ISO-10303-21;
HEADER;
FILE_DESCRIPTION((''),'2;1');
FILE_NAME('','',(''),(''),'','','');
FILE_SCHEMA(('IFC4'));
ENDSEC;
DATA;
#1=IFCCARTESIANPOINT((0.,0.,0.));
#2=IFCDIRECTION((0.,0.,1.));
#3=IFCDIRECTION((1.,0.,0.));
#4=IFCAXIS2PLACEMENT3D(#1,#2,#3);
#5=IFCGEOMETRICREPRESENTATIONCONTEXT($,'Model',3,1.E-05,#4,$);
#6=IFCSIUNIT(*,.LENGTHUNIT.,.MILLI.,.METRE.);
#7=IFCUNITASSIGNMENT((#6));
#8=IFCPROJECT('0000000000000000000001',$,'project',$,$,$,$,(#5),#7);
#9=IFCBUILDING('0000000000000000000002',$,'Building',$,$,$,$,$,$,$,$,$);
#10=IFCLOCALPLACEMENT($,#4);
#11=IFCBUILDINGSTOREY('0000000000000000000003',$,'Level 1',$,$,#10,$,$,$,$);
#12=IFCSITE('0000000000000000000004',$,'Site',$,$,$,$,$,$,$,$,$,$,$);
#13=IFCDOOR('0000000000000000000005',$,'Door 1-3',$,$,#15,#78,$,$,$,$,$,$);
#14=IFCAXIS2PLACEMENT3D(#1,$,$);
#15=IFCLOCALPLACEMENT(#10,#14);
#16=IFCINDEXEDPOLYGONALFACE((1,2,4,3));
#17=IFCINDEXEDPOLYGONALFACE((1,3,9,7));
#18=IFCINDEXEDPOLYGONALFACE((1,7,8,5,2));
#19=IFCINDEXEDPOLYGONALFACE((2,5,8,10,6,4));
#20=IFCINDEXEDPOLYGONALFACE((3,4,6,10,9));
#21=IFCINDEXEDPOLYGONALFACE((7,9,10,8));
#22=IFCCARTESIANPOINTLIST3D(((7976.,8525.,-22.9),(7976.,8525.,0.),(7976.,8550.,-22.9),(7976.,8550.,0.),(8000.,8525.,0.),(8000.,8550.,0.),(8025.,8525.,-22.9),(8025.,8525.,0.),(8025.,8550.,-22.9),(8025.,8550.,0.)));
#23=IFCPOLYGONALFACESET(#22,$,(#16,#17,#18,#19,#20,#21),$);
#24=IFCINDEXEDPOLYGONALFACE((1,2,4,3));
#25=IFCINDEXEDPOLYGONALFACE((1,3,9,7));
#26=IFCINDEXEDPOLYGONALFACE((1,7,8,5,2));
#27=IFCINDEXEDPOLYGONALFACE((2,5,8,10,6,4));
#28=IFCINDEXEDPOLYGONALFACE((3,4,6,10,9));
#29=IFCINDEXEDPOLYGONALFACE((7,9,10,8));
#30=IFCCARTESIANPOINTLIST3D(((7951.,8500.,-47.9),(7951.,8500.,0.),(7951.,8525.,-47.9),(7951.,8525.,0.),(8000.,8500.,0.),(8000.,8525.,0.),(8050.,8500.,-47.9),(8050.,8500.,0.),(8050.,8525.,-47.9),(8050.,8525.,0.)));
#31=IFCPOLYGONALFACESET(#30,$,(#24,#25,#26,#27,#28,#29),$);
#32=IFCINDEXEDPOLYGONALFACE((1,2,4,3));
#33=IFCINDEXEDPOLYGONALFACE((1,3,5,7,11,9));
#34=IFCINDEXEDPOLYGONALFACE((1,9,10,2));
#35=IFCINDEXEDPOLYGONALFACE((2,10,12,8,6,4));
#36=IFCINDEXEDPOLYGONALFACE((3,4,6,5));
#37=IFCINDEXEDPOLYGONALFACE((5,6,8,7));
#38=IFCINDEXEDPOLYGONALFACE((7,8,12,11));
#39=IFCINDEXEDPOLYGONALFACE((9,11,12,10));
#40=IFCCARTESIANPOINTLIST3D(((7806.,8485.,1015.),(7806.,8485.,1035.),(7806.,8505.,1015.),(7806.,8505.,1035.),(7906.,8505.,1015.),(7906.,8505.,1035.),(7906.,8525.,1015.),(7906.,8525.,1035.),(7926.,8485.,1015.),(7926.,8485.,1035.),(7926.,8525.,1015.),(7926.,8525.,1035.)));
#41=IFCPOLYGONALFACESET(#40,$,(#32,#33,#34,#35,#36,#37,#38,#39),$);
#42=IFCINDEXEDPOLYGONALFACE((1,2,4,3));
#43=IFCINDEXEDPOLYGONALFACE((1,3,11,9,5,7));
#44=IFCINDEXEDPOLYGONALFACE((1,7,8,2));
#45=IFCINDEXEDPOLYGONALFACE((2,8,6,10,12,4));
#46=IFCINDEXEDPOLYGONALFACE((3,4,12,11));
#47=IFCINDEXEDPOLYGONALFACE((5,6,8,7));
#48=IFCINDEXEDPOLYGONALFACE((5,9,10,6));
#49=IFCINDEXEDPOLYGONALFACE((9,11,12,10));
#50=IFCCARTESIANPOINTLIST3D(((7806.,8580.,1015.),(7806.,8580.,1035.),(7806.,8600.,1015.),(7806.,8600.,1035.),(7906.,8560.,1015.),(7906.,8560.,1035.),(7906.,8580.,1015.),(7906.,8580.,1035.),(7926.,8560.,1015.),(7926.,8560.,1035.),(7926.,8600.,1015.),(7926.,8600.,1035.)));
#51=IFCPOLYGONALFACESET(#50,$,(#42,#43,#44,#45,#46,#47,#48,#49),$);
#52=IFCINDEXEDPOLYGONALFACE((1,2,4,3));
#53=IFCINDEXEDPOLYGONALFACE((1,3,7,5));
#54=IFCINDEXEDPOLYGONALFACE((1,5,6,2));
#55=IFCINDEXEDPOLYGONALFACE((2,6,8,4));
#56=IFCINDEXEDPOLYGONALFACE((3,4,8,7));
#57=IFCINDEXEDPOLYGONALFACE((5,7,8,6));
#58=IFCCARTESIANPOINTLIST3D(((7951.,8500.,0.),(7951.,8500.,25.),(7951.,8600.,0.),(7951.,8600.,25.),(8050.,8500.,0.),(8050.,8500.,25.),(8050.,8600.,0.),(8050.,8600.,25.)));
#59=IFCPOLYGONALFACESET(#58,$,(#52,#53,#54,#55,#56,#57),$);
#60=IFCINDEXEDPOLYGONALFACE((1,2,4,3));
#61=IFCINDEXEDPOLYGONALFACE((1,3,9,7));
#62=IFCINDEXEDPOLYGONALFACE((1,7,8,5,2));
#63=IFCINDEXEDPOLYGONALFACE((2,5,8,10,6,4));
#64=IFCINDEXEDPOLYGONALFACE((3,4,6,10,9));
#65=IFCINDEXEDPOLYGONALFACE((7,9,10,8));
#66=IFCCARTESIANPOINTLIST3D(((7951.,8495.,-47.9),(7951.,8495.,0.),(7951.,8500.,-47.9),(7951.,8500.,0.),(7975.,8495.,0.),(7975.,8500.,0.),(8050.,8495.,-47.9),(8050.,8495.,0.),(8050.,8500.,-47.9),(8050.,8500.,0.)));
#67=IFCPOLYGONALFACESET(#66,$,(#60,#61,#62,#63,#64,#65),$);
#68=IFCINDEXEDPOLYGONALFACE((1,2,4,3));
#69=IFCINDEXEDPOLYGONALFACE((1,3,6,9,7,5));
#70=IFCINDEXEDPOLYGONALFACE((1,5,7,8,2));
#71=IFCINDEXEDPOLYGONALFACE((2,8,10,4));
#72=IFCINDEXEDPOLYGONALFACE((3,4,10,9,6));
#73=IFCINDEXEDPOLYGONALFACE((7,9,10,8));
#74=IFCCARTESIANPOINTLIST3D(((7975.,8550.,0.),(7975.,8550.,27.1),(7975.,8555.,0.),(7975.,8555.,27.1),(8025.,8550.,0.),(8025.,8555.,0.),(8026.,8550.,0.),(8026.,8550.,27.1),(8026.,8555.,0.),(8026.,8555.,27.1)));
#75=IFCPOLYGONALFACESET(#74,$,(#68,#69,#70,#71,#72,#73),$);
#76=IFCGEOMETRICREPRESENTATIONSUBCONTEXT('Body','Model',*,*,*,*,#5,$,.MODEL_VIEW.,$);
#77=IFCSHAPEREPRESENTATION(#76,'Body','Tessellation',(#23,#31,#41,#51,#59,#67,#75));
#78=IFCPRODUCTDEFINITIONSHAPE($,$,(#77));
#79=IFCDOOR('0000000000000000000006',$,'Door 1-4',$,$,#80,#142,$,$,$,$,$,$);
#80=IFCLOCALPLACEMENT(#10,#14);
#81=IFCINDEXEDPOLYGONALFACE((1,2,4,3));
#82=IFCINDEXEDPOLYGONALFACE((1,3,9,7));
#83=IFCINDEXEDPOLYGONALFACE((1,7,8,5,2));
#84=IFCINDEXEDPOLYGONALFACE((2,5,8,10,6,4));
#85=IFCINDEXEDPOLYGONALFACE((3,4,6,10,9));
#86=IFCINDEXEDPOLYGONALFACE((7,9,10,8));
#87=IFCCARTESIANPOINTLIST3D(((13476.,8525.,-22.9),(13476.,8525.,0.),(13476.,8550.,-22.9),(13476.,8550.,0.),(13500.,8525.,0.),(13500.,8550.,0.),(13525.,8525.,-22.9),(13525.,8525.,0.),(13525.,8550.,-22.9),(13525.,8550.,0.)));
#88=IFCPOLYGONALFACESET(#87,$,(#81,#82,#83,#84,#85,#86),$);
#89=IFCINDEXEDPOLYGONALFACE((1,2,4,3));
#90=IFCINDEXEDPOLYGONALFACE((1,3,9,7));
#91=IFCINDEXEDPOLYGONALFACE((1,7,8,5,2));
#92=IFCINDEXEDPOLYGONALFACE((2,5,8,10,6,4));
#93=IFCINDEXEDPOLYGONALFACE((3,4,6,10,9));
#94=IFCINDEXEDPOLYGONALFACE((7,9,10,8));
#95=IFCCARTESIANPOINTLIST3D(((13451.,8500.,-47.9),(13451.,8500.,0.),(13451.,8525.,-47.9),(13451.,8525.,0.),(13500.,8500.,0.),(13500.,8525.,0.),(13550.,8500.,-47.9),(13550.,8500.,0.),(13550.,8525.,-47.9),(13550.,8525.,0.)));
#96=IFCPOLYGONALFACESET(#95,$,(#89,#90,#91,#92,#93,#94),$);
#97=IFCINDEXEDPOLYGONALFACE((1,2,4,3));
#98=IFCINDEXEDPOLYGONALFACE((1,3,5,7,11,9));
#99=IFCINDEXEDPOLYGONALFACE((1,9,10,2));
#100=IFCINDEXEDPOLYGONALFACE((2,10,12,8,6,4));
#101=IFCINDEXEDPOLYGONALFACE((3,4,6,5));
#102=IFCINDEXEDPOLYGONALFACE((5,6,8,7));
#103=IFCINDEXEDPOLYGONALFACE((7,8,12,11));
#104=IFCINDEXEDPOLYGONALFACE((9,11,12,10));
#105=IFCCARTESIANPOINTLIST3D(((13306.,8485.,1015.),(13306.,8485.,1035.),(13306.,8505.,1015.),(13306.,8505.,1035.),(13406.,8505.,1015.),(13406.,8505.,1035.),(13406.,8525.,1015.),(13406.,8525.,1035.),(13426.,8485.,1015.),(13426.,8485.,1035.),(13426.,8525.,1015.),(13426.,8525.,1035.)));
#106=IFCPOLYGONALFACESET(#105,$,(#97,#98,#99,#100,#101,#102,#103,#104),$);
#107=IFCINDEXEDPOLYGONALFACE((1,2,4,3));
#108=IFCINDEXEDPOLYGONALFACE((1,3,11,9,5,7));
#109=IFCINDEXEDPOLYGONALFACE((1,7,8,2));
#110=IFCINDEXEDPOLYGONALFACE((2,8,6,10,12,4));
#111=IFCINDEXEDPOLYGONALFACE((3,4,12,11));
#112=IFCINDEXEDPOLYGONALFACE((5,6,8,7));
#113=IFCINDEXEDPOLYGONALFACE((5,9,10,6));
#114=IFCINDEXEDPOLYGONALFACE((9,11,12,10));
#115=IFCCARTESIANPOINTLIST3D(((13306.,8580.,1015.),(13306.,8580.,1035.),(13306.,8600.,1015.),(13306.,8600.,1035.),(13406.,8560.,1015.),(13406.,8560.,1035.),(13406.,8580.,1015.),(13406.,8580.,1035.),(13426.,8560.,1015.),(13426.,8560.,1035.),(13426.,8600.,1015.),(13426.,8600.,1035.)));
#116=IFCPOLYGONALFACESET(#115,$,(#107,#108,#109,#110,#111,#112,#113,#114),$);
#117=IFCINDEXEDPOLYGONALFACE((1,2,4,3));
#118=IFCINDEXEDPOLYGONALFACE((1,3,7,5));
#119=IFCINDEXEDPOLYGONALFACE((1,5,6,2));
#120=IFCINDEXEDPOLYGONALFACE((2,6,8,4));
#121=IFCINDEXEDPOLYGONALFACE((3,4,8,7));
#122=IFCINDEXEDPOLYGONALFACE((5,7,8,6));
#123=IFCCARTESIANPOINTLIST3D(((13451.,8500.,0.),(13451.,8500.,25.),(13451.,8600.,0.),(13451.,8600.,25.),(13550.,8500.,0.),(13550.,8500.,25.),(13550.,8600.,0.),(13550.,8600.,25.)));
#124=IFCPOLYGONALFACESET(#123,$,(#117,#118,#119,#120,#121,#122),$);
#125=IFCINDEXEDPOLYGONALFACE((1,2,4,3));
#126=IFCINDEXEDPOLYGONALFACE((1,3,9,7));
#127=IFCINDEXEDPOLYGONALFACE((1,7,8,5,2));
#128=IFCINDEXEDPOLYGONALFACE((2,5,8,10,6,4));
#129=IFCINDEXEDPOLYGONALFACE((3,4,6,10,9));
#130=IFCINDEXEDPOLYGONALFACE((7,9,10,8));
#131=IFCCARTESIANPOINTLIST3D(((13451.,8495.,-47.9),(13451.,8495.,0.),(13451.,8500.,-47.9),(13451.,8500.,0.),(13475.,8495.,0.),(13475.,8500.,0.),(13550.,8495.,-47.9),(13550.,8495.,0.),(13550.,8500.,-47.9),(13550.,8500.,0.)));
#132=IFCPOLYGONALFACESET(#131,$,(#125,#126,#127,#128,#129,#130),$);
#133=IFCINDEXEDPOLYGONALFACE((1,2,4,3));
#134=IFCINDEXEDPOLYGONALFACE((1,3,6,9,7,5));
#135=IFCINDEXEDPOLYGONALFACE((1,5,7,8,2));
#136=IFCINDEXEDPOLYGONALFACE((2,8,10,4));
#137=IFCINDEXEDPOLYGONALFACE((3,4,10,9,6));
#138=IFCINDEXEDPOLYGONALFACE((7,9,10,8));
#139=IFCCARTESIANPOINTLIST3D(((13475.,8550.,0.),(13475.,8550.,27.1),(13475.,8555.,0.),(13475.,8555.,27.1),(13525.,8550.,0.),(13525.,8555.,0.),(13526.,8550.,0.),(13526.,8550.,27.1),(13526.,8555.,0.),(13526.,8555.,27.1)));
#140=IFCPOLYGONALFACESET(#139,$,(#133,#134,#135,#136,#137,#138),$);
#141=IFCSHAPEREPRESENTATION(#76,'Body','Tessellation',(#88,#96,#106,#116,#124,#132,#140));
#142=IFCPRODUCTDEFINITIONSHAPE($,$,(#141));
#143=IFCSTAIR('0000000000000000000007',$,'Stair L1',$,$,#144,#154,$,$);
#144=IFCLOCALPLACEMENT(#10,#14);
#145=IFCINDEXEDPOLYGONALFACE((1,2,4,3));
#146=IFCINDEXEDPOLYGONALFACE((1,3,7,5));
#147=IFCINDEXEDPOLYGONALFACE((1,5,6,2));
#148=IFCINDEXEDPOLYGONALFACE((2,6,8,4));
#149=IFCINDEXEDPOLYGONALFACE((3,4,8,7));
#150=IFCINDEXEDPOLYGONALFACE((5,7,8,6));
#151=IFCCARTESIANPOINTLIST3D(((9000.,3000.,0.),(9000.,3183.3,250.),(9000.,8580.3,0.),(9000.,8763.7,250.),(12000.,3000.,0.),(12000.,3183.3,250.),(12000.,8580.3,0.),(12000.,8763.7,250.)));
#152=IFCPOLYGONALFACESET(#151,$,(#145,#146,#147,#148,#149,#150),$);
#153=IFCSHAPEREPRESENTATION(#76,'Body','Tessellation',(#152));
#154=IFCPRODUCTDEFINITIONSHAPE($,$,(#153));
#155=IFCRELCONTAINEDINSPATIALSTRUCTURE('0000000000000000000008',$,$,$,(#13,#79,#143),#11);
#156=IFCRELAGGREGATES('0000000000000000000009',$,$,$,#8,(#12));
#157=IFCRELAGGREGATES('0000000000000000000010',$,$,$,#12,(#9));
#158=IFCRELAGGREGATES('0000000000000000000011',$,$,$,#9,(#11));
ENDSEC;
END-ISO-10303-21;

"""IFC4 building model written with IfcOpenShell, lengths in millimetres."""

from ifc_helpers import new_model, si_unit, frame, origin_with_axes, place, context, subcontext, project, spatial, line, indexed_curve, outline, extrude, element, save


model = new_model("IFC4")

# Units and contexts
model_context = context("Model", 3, precision=1e-05, world=origin_with_axes())
body_context = subcontext(model_context, "Body", "Model", "MODEL_VIEW")
ifc_project = project(units=[si_unit("LENGTHUNIT", "METRE", prefix="MILLI")], contexts=[model_context])

# Site, building, storey
site = spatial("IfcSite", under=ifc_project, Name="Site")
building = spatial("IfcBuilding", under=site, Name="Building")
storey_placement = place(None, origin_with_axes())
storey = spatial("IfcBuildingStorey", under=building, at=storey_placement, Name="Level 1")

# Doors
door_1_placement = place(storey_placement, frame((8000.0, 8500.0, 0.0), z_axis=(0.0, 0.0, 1.0), x_axis=(1.0, 0.0, 0.0)))
element("IfcDoor", 1, at=door_1_placement, inside=storey, Name="Door 1-3", context=body_context, shape_type="SweptSolid", body=[
    extrude(outline(indexed_curve([(0.0, 0.0), (0.0, 2.1), (1.0, 2.1), (1.0, 0.0), (-24.0, 0.0), (-24.0, -22.9), (25.0, -22.9), (25.0, 0.0)], segments=[line(1, 2, 3, 4, 5, 6, 7, 8, 1)])), frame((0.0, 25.0, 0.0), z_axis=(0.0, -1.0, 0.0), x_axis=(1.0, 0.0, 0.0)), (0.0, 0.0, -1.0), 25.0),
    extrude(outline(indexed_curve([(0.0, 0.0), (0.0, 2.1), (1.0, 2.1), (1.0, 0.0), (-49.0, 0.0), (-49.0, -47.9), (50.0, -47.9), (50.0, 0.0)], segments=[line(1, 2, 3, 4, 5, 6, 7, 8, 1)])), frame((0.0, 0.0, 0.0), z_axis=(0.0, -1.0, 0.0), x_axis=(1.0, 0.0, 0.0)), (0.0, 0.0, -1.0), 25.0),
    extrude(outline(indexed_curve([(0.0, 0.0), (-49.0, 0.0), (-49.0, 35.0), (0.0, 35.0)], segments=[line(1, 2, 3, 4, 1)])), frame((25.0, 25.0, 25.0), z_axis=(0.0, 0.0, 1.0), x_axis=(1.0, 0.0, 0.0)), (0.0, 0.0, 1.0), -47.9),
    extrude(outline(indexed_curve([(0.0, 0.0), (0.0, -40.0), (-120.0, -40.0), (-120.0, -20.0), (-20.0, -20.0), (-20.0, 0.0)], segments=[line(1, 2, 3, 4, 5, 6, 1)])), frame((-74.0, 25.0, 1015.0), z_axis=(0.0, 0.0, 1.0), x_axis=(1.0, 0.0, 0.0)), (0.0, 0.0, 1.0), 20.0),
    extrude(outline(indexed_curve([(0.0, 0.0), (0.0, 40.0), (-120.0, 40.0), (-120.0, 20.0), (-20.0, 20.0), (-20.0, 0.0)], segments=[line(1, 2, 3, 4, 5, 6, 1)])), frame((-74.0, 60.0, 1015.0), z_axis=(0.0, 0.0, 1.0), x_axis=(1.0, 0.0, 0.0)), (0.0, 0.0, 1.0), 20.0),
    extrude(outline(indexed_curve([(0.0, 0.0), (-99.0, 0.0), (-99.0, 100.0), (0.0, 100.0)], segments=[line(1, 2, 3, 4, 1)])), frame((50.0, 0.0, 0.0), z_axis=(0.0, 0.0, 1.0), x_axis=(1.0, 0.0, 0.0)), (0.0, 0.0, 1.0), 25.0),
    extrude(outline(indexed_curve([(0.0, 0.0), (0.0, 27.1), (51.0, 27.1), (51.0, 0.0), (-24.0, 0.0), (-24.0, -47.9), (75.0, -47.9), (75.0, 0.0)], segments=[line(1, 2, 3, 4, 5, 6, 7, 8, 1)])), frame((-25.0, -5.0, 0.0), z_axis=(0.0, -1.0, 0.0), x_axis=(1.0, 0.0, 0.0)), (0.0, 0.0, -1.0), 5.0),
    extrude(outline(indexed_curve([(0.0, 0.0), (0.0, 27.1), (51.0, 27.1), (51.0, 0.0), (1.0, 0.0), (1.0, -22.9), (50.0, -22.9), (50.0, 0.0)], segments=[line(1, 2, 3, 4, 5, 6, 7, 8, 1)])), frame((-25.0, 50.0, 0.0), z_axis=(0.0, -1.0, 0.0), x_axis=(1.0, 0.0, 0.0)), (0.0, 0.0, -1.0), 5.0),
])
door_2_placement = place(storey_placement, frame((13500.0, 8500.0, 0.0), z_axis=(0.0, 0.0, 1.0), x_axis=(1.0, 0.0, 0.0)))
element("IfcDoor", 2, at=door_2_placement, inside=storey, Name="Door 1-4", context=body_context, shape_type="SweptSolid", body=[
    extrude(outline(indexed_curve([(0.0, 0.0), (0.0, 2.1), (1.0, 2.1), (1.0, 0.0), (-24.0, 0.0), (-24.0, -22.9), (25.0, -22.9), (25.0, 0.0)], segments=[line(1, 2, 3, 4, 5, 6, 7, 8, 1)])), frame((0.0, 25.0, 0.0), z_axis=(0.0, -1.0, 0.0), x_axis=(1.0, 0.0, 0.0)), (0.0, 0.0, -1.0), 25.0),
    extrude(outline(indexed_curve([(0.0, 0.0), (0.0, 2.1), (1.0, 2.1), (1.0, 0.0), (-49.0, 0.0), (-49.0, -47.9), (50.0, -47.9), (50.0, 0.0)], segments=[line(1, 2, 3, 4, 5, 6, 7, 8, 1)])), frame((0.0, 0.0, 0.0), z_axis=(0.0, -1.0, 0.0), x_axis=(1.0, 0.0, 0.0)), (0.0, 0.0, -1.0), 25.0),
    extrude(outline(indexed_curve([(0.0, 0.0), (-49.0, 0.0), (-49.0, 35.0), (0.0, 35.0)], segments=[line(1, 2, 3, 4, 1)])), frame((25.0, 25.0, 25.0), z_axis=(0.0, 0.0, 1.0), x_axis=(1.0, 0.0, 0.0)), (0.0, 0.0, 1.0), -47.9),
    extrude(outline(indexed_curve([(0.0, 0.0), (0.0, -40.0), (-120.0, -40.0), (-120.0, -20.0), (-20.0, -20.0), (-20.0, 0.0)], segments=[line(1, 2, 3, 4, 5, 6, 1)])), frame((-74.0, 25.0, 1015.0), z_axis=(0.0, 0.0, 1.0), x_axis=(1.0, 0.0, 0.0)), (0.0, 0.0, 1.0), 20.0),
    extrude(outline(indexed_curve([(0.0, 0.0), (0.0, 40.0), (-120.0, 40.0), (-120.0, 20.0), (-20.0, 20.0), (-20.0, 0.0)], segments=[line(1, 2, 3, 4, 5, 6, 1)])), frame((-74.0, 60.0, 1015.0), z_axis=(0.0, 0.0, 1.0), x_axis=(1.0, 0.0, 0.0)), (0.0, 0.0, 1.0), 20.0),
    extrude(outline(indexed_curve([(0.0, 0.0), (-99.0, 0.0), (-99.0, 100.0), (0.0, 100.0)], segments=[line(1, 2, 3, 4, 1)])), frame((50.0, 0.0, 0.0), z_axis=(0.0, 0.0, 1.0), x_axis=(1.0, 0.0, 0.0)), (0.0, 0.0, 1.0), 25.0),
    extrude(outline(indexed_curve([(0.0, 0.0), (0.0, 27.1), (51.0, 27.1), (51.0, 0.0), (-24.0, 0.0), (-24.0, -47.9), (75.0, -47.9), (75.0, 0.0)], segments=[line(1, 2, 3, 4, 5, 6, 7, 8, 1)])), frame((-25.0, -5.0, 0.0), z_axis=(0.0, -1.0, 0.0), x_axis=(1.0, 0.0, 0.0)), (0.0, 0.0, -1.0), 5.0),
    extrude(outline(indexed_curve([(0.0, 0.0), (0.0, 27.1), (51.0, 27.1), (51.0, 0.0), (1.0, 0.0), (1.0, -22.9), (50.0, -22.9), (50.0, 0.0)], segments=[line(1, 2, 3, 4, 5, 6, 7, 8, 1)])), frame((-25.0, 50.0, 0.0), z_axis=(0.0, -1.0, 0.0), x_axis=(1.0, 0.0, 0.0)), (0.0, 0.0, -1.0), 5.0),
])

# Stair
stair_placement = place(storey_placement, frame((9000.0, 3000.0, 0.0), z_axis=(0.0, 0.0, 1.0), x_axis=(1.0, 0.0, 0.0)))
element("IfcStair", 3, at=stair_placement, inside=storey, Name="Stair L1", context=body_context, shape_type="SweptSolid", body=[
    extrude(outline(indexed_curve([(0.0, 0.0), (3000.0, 0.0), (3000.0, 5580.3), (0.0, 5580.3), (0.0, 0.0)])), None, (0.0, 0.591364, 0.806405), 310.0),
])

save(model, "model.ifc")
